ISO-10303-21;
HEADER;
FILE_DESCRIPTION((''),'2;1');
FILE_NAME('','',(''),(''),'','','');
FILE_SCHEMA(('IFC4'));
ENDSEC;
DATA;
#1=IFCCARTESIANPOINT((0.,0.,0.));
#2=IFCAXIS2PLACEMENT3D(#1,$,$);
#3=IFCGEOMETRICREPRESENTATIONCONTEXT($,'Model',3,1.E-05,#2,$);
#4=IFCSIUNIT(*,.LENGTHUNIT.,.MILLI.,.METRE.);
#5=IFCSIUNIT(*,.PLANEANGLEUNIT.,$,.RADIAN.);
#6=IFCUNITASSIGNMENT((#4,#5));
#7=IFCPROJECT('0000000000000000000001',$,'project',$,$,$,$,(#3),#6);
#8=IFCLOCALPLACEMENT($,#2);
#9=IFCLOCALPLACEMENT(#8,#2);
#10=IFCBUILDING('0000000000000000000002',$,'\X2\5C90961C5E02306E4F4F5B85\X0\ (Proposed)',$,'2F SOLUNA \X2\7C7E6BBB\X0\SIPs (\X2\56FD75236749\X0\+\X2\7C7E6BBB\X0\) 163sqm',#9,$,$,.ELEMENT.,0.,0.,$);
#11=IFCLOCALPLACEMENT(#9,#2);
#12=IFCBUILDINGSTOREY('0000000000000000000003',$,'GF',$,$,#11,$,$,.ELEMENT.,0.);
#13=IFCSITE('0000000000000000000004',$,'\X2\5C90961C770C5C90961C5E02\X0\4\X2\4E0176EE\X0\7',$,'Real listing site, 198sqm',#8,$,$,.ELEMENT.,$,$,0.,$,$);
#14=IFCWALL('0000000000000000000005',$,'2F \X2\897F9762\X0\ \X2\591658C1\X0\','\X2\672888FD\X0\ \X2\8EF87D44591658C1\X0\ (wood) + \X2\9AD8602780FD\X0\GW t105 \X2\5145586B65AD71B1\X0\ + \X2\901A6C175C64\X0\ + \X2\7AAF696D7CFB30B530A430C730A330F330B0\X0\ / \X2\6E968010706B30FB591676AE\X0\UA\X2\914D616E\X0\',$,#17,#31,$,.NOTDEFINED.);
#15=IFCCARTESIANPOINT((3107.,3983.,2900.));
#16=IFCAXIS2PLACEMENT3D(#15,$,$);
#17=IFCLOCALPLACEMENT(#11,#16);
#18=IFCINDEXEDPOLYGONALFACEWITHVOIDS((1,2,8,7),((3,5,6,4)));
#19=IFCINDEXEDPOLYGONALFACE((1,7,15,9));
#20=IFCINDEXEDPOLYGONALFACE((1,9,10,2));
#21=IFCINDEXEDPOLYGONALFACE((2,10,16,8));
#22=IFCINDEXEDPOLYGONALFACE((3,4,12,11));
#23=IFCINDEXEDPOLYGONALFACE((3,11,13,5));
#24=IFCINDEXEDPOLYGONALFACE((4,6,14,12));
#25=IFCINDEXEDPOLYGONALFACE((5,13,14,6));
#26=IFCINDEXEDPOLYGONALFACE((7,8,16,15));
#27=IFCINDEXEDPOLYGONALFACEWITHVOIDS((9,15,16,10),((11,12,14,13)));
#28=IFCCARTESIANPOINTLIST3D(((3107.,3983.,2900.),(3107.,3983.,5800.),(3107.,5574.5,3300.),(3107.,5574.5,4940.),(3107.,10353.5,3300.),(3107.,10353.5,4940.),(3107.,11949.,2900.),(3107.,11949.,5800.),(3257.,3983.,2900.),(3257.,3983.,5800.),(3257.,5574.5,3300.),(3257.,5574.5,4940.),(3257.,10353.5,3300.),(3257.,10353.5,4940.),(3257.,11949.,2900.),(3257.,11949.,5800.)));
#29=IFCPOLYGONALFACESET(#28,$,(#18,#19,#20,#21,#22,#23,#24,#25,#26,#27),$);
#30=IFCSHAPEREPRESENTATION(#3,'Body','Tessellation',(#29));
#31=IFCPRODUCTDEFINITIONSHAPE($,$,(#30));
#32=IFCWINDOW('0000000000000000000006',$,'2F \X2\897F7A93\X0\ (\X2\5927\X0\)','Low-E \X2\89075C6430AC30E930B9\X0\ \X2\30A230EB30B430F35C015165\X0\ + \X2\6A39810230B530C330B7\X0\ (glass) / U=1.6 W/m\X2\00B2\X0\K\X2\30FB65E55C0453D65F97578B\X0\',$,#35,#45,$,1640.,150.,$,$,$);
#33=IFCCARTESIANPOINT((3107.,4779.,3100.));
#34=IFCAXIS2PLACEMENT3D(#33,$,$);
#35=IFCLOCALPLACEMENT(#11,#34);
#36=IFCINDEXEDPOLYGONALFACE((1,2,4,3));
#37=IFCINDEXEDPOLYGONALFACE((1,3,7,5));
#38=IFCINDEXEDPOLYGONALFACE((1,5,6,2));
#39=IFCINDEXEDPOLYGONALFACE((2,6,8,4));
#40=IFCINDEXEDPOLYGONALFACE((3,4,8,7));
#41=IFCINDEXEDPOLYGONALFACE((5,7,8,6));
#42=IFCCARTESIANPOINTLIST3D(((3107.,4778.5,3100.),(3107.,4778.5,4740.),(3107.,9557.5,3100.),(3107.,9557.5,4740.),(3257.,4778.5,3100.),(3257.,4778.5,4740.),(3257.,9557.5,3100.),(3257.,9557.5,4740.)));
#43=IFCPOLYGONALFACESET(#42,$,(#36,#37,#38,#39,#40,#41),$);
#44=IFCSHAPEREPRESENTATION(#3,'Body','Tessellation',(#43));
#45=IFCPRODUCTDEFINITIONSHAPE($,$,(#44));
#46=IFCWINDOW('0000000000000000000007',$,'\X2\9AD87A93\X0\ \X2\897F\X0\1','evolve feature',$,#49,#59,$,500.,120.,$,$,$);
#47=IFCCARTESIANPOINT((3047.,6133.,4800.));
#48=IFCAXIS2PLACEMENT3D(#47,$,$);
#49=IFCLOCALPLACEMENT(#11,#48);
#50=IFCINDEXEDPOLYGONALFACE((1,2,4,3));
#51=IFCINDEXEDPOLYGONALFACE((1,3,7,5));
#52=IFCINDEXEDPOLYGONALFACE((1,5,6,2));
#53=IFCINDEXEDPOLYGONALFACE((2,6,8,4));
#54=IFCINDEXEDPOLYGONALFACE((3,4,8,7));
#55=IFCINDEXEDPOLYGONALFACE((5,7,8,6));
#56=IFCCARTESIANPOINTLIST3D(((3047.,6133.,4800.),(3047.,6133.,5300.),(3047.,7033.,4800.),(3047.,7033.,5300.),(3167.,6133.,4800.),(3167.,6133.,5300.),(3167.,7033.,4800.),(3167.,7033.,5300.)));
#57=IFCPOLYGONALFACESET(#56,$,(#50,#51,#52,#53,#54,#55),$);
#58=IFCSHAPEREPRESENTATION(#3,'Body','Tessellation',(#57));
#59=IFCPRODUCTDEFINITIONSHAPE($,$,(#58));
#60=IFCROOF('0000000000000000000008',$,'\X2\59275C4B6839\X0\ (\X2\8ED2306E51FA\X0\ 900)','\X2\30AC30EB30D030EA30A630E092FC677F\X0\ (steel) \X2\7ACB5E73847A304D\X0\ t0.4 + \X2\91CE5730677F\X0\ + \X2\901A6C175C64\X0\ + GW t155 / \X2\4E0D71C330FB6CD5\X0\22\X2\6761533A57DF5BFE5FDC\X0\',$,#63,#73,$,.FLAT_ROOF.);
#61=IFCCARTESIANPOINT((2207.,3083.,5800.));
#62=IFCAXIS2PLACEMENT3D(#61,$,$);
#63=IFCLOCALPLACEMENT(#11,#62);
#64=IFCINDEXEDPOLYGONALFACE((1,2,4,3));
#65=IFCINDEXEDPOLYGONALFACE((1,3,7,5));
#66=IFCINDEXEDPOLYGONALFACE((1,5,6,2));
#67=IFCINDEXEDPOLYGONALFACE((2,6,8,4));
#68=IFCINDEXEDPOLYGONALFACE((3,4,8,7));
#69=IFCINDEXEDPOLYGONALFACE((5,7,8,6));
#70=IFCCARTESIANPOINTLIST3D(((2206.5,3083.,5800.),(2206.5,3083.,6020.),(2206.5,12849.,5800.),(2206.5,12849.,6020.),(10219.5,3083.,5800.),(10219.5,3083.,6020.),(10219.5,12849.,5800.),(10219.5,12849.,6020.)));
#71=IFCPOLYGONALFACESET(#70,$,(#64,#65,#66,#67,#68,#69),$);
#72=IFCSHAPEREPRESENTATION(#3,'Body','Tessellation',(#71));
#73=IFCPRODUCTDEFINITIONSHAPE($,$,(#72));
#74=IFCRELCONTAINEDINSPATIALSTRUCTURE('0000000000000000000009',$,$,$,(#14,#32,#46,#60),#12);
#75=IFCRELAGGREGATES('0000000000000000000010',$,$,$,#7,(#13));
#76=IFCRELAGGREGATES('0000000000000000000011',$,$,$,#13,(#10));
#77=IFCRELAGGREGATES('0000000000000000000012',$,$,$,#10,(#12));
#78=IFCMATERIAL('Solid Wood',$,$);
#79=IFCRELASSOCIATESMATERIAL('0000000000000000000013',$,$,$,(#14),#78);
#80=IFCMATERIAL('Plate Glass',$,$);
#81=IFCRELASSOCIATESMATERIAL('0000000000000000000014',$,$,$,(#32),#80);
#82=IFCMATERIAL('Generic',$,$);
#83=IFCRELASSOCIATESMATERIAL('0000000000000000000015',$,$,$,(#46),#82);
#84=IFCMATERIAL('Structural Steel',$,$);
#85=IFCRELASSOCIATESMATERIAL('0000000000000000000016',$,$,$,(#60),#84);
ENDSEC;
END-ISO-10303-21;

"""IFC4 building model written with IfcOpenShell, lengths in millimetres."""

from ifc_helpers import new_model, si_unit, frame, frame_2d, origin, place, context, project, spatial, rectangle, extrude, material, element, fill, save


model = new_model("IFC4")

# Units and contexts
model_context = context("Model", 3, precision=1e-05, world=origin())
ifc_project = project(units=[si_unit("LENGTHUNIT", "METRE", prefix="MILLI"), si_unit("PLANEANGLEUNIT", "RADIAN")], contexts=[model_context])

# Site, building, storey
site_placement = place(None, origin())
site = spatial("IfcSite", under=ifc_project, at=site_placement, Name="岐阜県岐阜市4丁目7", ObjectType="Real listing site, 198sqm", CompositionType="ELEMENT", RefElevation=0.0)
building_placement = place(site_placement, origin())
building = spatial("IfcBuilding", under=site, at=building_placement, Name="岐阜市の住宅 (Proposed)", ObjectType="2F SOLUNA 籾殻SIPs (国産杉+籾殻) 163sqm", CompositionType="ELEMENT", ElevationOfRefHeight=0.0, ElevationOfTerrain=0.0)
storey_placement = place(building_placement, origin())
storey = spatial("IfcBuildingStorey", under=building, at=storey_placement, Name="GF", CompositionType="ELEMENT", Elevation=0.0)

# Shared definitions
ifc_material_1 = material(Name="Solid Wood")
ifc_material_2 = material(Name="Generic")

# Shared definitions
ifc_material_3 = material(Name="Plate Glass")

# Wall, openings, windows
wall_1_placement = place(storey_placement, frame((3107.0, 3983.0, 2900.0)))
wall_1 = element("IfcWall", 1, at=wall_1_placement, inside=storey, material=ifc_material_1, Name="2F 西面 外壁", Description="木製 軸組外壁 (wood) + 高性能GW t105 充填断熱 + 通気層 + 窯業系サイディング / 準耐火・外皮UA配慮", PredefinedType="NOTDEFINED", context=model_context, shape_type="SweptSolid", body=[
    extrude(rectangle(XDim=150.0, YDim=7966.0, at=frame_2d((75.0, 3983.0))), frame((3107.0, 3983.0, 2900.0)), (0.0, 0.0, 1.0), 2900.0),
])
opening_1_placement = place(storey_placement, frame((3107.0, 4779.0, 3100.0)))
opening_1 = element("IfcOpeningElement", 2, at=opening_1_placement, cuts=wall_1, PredefinedType="NOTDEFINED", context=model_context, shape_type="SweptSolid", body=[
    extrude(rectangle(XDim=150.0, YDim=4779.0, at=frame_2d((75.0, 2389.0))), frame((3107.0, 4779.0, 3100.0)), (0.0, 0.0, 1.0), 1640.0),
])
opening_2_placement = place(storey_placement, frame((3047.0, 6133.0, 4800.0)))
opening_2 = element("IfcOpeningElement", 3, at=opening_2_placement, cuts=wall_1, PredefinedType="NOTDEFINED", context=model_context, shape_type="SweptSolid", body=[
    extrude(rectangle(XDim=120.0, YDim=900.0, at=frame_2d((60.0, 450.0))), frame((3047.0, 6133.0, 4800.0)), (0.0, 0.0, 1.0), 500.0),
])
window_1_placement = place(storey_placement, frame((3107.0, 4779.0, 3100.0)))
window_1 = element("IfcWindow", 4, at=window_1_placement, inside=storey, material=ifc_material_3, Name="2F 西窓 (大)", Description="Low-E 複層ガラス アルゴン封入 + 樹脂サッシ (glass) / U=1.6 W/m²K・日射取得型", OverallHeight=1640.0, OverallWidth=150.0, context=model_context, shape_type="SweptSolid", body=[
    extrude(rectangle(XDim=150.0, YDim=4779.0, at=frame_2d((75.0, 2389.0))), frame((3107.0, 4779.0, 3100.0)), (0.0, 0.0, 1.0), 1640.0),
])
fill(opening_1, window_1)
window_2_placement = place(storey_placement, frame((3047.0, 6133.0, 4800.0)))
window_2 = element("IfcWindow", 5, at=window_2_placement, inside=storey, material=ifc_material_2, Name="高窓 西1", Description="evolve feature", OverallHeight=500.0, OverallWidth=120.0, context=model_context, shape_type="SweptSolid", body=[
    extrude(rectangle(XDim=120.0, YDim=900.0, at=frame_2d((60.0, 450.0))), frame((3047.0, 6133.0, 4800.0)), (0.0, 0.0, 1.0), 500.0),
])
fill(opening_2, window_2)

# Roof
ifc_material_4 = material(Name="Structural Steel")
roof_1_placement = place(storey_placement, frame((2207.0, 3083.0, 5800.0)))
element("IfcRoof", 6, at=roof_1_placement, inside=storey, material=ifc_material_4, Name="大屋根 (軒の出 900)", Description="ガルバリウム鋼板 (steel) 立平葺き t0.4 + 野地板 + 通気層 + GW t155 / 不燃・法22条区域対応", PredefinedType="FLAT_ROOF", context=model_context, shape_type="SweptSolid", body=[
    extrude(rectangle(XDim=8013.0, YDim=9766.0, at=frame_2d((4006.0, 4883.0))), frame((2207.0, 3083.0, 5800.0)), (0.0, 0.0, 1.0), 220.0),
])

save(model, "model.ifc")
